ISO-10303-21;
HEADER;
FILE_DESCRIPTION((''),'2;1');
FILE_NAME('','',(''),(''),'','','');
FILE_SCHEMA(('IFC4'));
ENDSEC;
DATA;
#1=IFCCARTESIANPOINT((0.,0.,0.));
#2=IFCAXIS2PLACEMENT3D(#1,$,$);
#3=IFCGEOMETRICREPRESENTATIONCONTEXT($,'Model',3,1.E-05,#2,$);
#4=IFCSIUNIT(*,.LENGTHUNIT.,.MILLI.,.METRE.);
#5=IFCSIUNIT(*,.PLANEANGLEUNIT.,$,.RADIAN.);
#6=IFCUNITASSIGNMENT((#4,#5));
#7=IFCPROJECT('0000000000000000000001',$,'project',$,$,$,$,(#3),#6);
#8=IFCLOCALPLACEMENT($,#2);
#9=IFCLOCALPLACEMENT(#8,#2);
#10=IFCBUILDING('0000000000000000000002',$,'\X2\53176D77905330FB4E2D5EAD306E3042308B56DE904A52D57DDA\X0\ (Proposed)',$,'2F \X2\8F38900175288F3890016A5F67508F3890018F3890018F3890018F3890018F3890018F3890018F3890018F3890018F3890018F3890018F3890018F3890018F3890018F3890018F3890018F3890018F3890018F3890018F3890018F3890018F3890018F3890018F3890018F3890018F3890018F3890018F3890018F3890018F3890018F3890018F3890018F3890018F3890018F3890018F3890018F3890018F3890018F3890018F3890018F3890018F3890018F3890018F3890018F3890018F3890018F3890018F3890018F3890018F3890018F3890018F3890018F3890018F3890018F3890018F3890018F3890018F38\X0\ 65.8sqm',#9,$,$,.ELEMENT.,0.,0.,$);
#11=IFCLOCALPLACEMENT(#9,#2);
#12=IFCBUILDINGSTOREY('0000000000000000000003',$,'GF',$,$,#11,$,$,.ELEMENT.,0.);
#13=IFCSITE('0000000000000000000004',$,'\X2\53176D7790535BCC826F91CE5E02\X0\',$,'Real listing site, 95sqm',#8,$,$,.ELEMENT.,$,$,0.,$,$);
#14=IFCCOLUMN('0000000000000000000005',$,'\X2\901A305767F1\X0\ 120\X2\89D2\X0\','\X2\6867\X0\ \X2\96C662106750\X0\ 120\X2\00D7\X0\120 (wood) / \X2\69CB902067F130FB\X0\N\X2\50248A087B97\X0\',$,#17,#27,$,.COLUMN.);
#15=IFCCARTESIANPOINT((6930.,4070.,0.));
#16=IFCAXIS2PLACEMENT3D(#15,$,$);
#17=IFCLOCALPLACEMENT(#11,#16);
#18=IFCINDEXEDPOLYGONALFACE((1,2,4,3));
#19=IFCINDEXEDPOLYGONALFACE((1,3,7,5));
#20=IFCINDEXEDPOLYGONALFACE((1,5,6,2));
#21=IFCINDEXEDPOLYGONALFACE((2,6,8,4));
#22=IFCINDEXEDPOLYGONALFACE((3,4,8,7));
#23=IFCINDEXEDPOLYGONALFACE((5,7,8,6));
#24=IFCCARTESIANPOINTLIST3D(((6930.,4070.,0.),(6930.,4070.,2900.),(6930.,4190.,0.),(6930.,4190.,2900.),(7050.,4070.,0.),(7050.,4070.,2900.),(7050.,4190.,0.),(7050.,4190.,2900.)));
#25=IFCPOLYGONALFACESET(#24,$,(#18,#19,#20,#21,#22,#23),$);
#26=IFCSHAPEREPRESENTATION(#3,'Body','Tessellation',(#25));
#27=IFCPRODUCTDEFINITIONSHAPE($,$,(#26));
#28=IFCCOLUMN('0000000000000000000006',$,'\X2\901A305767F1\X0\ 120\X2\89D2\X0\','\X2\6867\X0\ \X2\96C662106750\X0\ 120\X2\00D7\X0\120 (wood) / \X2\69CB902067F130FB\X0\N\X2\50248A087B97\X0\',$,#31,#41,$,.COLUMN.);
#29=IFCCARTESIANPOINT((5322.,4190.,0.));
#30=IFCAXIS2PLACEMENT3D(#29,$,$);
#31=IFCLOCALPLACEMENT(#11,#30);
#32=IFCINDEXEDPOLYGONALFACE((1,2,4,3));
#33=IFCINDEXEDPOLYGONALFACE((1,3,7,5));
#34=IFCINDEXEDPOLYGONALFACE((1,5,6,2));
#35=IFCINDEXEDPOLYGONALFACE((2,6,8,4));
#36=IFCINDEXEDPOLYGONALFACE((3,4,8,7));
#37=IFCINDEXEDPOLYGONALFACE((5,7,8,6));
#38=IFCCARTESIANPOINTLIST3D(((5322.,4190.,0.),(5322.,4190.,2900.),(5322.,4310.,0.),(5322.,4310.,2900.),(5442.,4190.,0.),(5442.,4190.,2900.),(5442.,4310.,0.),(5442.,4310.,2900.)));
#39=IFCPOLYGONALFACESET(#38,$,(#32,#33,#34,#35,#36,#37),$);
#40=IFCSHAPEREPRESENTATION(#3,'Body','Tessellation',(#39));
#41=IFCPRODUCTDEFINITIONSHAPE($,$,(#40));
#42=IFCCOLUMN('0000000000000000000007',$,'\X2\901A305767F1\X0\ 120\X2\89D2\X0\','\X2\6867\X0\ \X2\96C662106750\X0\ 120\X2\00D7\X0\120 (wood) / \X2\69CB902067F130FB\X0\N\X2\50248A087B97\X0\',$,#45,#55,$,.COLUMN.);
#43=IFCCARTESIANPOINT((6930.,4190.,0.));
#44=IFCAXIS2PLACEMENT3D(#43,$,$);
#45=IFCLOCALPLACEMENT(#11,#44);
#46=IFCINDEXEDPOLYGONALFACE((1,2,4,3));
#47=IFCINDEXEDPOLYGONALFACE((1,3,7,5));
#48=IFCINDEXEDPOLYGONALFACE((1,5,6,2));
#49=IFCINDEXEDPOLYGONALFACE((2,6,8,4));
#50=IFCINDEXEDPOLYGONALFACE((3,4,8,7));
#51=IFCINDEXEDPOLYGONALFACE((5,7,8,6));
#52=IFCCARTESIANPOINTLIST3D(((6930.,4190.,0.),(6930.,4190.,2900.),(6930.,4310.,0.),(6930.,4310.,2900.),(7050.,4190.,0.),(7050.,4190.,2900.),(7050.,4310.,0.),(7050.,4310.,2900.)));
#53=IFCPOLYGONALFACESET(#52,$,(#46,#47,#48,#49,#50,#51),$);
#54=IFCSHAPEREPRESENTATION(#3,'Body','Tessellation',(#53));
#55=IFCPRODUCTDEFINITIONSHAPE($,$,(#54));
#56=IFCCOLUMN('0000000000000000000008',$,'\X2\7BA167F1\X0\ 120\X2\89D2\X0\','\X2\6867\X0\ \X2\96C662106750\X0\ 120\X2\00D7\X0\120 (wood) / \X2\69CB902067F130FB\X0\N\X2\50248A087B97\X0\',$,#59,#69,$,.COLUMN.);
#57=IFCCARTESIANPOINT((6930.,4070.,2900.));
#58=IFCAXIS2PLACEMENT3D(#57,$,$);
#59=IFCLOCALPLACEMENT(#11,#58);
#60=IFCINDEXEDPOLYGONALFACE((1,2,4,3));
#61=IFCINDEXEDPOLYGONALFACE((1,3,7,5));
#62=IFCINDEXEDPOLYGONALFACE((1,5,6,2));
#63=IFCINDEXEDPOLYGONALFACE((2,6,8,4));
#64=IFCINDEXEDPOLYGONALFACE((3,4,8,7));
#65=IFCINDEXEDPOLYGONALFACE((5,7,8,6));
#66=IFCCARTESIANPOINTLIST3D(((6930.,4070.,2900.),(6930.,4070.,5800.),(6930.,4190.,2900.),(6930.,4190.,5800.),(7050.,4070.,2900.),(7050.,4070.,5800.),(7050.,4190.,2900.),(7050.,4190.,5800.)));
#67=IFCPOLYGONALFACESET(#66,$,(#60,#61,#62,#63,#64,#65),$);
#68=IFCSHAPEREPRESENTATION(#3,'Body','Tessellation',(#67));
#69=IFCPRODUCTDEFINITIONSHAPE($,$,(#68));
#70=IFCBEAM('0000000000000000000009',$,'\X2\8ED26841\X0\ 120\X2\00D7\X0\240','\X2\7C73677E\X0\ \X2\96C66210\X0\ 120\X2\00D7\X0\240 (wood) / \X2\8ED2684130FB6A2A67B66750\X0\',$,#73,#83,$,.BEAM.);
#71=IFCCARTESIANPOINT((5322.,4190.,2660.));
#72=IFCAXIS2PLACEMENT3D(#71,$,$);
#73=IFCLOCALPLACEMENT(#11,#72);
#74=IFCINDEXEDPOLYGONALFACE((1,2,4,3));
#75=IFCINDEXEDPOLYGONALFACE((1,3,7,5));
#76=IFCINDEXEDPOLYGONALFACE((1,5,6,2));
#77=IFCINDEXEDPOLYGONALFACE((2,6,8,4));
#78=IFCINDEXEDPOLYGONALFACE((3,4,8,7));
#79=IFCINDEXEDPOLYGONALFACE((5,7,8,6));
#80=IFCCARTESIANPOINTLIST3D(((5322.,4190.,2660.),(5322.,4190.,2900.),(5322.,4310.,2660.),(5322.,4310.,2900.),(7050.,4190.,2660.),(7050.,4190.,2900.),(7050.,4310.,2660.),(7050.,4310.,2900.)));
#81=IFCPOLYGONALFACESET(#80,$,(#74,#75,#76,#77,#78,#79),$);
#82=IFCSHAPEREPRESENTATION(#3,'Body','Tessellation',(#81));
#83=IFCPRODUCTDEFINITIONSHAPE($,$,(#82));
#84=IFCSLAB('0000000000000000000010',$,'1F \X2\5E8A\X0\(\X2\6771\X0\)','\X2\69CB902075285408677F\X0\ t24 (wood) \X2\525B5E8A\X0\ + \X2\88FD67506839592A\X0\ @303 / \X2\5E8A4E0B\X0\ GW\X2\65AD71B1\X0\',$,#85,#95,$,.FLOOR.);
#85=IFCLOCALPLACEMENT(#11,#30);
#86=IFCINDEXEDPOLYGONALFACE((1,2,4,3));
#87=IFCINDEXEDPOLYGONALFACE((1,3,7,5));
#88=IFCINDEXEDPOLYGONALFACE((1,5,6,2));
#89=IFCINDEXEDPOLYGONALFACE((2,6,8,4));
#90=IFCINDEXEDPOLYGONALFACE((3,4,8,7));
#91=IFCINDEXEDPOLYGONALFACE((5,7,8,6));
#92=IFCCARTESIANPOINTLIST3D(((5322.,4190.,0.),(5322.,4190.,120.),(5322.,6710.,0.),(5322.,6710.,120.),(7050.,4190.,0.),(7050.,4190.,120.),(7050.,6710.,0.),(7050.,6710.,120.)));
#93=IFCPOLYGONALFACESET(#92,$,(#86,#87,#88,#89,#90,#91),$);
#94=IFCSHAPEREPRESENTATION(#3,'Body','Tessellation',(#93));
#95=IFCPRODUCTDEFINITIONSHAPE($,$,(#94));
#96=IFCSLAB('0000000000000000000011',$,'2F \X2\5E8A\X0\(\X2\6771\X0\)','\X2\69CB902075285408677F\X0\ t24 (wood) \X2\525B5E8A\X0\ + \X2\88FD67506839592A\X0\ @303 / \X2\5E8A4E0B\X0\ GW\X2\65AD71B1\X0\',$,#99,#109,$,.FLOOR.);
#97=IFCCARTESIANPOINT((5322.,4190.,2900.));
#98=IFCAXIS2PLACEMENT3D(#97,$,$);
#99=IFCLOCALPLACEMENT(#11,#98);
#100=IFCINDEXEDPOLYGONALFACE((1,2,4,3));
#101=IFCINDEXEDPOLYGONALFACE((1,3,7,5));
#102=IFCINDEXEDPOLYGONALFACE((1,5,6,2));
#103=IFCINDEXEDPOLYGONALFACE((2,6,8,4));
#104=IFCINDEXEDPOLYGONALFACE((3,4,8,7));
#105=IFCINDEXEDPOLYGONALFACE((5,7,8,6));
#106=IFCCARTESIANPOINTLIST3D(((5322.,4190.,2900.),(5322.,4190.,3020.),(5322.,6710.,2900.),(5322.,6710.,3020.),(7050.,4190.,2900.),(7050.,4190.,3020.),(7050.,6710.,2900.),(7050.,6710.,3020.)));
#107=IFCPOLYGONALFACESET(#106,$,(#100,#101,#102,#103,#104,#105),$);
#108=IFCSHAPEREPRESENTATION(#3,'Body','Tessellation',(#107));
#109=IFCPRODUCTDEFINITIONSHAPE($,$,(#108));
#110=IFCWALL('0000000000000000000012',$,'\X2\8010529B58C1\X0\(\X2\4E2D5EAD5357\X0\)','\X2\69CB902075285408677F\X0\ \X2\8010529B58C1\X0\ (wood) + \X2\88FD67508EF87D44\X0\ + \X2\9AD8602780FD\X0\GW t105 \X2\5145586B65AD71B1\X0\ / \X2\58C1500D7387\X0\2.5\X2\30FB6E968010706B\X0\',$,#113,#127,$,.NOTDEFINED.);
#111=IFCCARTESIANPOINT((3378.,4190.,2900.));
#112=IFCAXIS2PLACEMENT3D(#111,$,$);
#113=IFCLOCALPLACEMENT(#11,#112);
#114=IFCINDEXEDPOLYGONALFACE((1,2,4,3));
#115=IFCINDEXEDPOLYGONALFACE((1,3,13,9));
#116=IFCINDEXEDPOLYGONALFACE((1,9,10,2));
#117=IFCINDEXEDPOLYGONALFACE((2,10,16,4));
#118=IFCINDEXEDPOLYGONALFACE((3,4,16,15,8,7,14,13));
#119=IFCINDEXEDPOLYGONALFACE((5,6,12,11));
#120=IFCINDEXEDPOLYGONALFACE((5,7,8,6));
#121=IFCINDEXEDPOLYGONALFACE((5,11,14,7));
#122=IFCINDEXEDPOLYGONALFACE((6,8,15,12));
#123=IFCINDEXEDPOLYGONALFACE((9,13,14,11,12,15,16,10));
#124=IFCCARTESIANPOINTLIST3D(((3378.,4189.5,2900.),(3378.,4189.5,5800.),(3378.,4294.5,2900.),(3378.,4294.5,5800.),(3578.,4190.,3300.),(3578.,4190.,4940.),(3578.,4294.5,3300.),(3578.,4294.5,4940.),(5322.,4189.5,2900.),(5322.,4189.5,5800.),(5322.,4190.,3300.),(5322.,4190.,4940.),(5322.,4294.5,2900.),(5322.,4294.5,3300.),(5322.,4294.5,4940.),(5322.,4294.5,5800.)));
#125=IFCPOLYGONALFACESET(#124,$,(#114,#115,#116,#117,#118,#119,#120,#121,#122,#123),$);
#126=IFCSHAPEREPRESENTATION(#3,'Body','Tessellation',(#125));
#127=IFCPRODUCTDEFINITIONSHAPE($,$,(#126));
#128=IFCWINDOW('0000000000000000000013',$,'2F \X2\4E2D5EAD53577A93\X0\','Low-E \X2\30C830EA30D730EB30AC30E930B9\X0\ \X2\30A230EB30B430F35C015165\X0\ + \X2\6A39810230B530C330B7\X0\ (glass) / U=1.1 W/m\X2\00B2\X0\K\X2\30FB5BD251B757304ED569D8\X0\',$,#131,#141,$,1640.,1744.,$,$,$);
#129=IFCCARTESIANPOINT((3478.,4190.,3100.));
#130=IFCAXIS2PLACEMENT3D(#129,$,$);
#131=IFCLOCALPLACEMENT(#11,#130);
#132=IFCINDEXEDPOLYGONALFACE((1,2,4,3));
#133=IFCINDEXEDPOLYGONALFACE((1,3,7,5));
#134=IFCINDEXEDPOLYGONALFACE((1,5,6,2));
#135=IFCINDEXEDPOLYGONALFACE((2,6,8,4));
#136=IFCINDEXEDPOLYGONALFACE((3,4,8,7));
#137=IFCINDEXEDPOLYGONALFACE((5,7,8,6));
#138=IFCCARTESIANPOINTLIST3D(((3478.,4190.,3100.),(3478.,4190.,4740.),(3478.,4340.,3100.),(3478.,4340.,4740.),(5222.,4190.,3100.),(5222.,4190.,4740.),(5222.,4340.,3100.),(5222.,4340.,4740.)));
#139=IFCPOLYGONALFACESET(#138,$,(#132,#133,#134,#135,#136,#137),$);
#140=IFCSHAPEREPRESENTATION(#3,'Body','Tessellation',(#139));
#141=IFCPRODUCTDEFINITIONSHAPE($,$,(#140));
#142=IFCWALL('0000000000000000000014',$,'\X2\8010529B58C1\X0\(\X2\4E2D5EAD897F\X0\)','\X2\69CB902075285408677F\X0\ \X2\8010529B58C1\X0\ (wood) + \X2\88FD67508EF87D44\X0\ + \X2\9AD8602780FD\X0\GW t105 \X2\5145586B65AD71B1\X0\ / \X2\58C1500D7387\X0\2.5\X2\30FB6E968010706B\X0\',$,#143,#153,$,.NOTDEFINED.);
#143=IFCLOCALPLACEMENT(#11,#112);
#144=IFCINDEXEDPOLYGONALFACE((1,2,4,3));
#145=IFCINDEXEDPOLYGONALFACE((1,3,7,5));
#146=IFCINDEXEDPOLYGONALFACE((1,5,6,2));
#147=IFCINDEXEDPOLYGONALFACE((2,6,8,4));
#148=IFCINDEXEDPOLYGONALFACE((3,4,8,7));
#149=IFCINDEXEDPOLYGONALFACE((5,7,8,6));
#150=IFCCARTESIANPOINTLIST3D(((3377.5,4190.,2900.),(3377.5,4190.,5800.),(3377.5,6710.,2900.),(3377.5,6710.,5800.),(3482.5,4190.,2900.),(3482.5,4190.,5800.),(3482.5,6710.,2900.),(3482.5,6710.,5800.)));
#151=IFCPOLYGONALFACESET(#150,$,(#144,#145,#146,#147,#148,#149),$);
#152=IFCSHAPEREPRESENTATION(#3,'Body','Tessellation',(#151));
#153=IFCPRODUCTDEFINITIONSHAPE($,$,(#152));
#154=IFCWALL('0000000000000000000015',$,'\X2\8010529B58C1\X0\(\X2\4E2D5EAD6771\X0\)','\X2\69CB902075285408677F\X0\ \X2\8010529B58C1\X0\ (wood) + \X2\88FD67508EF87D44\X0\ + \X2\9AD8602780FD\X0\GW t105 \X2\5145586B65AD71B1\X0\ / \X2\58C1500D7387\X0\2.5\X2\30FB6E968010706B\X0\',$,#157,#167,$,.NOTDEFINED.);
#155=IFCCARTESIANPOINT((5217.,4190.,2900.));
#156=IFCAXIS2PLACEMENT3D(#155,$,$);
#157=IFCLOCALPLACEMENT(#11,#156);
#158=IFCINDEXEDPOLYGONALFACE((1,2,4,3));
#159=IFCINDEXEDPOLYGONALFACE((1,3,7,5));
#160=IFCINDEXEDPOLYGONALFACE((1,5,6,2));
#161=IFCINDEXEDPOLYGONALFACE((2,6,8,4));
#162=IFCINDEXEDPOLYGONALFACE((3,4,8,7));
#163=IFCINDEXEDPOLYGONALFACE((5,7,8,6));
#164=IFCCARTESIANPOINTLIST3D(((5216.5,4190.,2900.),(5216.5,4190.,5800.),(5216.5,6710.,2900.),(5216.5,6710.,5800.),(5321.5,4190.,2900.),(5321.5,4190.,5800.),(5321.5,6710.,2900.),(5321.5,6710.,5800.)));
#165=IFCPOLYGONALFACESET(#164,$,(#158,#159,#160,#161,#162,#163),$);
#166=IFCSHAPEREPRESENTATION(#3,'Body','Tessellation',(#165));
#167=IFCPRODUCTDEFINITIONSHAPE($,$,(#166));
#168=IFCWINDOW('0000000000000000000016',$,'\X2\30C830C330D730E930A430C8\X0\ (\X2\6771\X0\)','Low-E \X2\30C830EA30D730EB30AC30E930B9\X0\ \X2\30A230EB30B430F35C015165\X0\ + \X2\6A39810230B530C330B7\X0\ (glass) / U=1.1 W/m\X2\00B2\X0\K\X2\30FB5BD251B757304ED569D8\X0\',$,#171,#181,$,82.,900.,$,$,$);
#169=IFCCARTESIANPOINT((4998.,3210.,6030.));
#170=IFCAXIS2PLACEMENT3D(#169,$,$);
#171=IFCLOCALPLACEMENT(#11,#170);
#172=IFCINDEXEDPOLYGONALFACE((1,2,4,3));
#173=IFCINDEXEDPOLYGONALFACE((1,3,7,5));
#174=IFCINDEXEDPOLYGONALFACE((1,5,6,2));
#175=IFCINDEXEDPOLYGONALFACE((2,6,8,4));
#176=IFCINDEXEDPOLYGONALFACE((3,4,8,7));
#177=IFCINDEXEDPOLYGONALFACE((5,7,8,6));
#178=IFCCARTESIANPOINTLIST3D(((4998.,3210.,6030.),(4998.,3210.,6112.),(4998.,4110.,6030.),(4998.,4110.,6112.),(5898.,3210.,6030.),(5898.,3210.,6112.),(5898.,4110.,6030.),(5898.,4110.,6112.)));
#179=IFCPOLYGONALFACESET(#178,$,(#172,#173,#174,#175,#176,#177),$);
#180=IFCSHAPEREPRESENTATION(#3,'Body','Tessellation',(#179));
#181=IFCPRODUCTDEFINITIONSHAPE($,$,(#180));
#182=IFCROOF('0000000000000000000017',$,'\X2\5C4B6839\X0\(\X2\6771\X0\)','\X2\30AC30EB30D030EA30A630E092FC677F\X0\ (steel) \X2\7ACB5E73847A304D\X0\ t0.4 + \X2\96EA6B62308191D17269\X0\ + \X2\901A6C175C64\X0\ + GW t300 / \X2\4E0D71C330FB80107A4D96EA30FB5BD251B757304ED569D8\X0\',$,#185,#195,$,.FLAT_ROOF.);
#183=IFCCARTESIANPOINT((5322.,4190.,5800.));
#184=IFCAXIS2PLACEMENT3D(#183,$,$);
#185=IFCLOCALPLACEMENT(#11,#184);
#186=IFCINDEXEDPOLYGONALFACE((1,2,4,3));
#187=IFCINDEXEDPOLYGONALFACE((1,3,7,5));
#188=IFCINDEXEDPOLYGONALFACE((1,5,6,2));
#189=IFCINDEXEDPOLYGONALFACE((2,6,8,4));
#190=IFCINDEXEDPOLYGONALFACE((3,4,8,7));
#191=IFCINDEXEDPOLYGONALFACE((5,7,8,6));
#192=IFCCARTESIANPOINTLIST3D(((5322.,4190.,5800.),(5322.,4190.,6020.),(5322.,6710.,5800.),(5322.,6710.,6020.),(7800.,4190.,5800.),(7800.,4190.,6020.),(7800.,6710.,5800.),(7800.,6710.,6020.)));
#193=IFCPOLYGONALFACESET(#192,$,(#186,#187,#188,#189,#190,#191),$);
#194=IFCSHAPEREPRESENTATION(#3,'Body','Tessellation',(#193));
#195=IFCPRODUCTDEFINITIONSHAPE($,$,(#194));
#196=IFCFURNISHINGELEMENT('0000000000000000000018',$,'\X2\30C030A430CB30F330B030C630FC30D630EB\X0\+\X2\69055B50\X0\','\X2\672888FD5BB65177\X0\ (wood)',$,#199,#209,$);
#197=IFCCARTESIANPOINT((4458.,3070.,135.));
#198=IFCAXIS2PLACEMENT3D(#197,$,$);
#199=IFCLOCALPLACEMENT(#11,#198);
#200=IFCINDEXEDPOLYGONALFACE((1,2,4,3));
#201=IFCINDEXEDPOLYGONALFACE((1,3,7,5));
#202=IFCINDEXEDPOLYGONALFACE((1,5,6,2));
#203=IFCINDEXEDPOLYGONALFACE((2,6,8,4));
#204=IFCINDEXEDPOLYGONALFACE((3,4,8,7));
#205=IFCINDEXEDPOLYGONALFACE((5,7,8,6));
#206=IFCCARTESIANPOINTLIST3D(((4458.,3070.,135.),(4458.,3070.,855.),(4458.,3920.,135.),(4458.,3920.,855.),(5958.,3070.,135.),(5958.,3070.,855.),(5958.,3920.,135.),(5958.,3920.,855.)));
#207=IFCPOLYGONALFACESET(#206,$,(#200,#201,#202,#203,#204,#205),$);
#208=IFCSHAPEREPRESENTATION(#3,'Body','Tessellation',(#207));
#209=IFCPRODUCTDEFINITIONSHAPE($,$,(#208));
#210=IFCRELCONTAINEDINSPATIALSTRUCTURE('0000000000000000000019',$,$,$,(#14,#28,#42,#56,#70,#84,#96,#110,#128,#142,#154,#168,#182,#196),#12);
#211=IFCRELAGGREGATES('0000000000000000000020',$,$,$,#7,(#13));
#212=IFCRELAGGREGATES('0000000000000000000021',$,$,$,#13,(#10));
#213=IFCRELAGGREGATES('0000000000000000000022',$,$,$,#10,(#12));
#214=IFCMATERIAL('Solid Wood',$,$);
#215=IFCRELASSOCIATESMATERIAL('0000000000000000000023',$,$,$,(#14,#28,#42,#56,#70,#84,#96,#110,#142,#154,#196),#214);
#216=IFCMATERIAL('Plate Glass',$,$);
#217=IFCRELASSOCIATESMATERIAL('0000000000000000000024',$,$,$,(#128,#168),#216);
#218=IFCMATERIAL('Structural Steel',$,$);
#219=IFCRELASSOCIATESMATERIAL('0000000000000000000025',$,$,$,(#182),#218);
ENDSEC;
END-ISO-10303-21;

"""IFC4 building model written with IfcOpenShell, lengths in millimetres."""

from ifc_helpers import new_model, si_unit, frame, frame_2d, origin, place, context, project, spatial, rectangle, extrude, material, element, fill, save


model = new_model("IFC4")

# Units and contexts
model_context = context("Model", 3, precision=1e-05, world=origin())
ifc_project = project(units=[si_unit("LENGTHUNIT", "METRE", prefix="MILLI"), si_unit("PLANEANGLEUNIT", "RADIAN")], contexts=[model_context])

# Site, building, storey
site_placement = place(None, origin())
site = spatial("IfcSite", under=ifc_project, at=site_placement, Name="北海道富良野市", ObjectType="Real listing site, 95sqm", CompositionType="ELEMENT", RefElevation=0.0)
building_placement = place(site_placement, origin())
building = spatial("IfcBuilding", under=site, at=building_placement, Name="北海道・中庭のある回遊動線 (Proposed)", ObjectType="2F 輸送用輸送機材輸送輸送輸送輸送輸送輸送輸送輸送輸送輸送輸送輸送輸送輸送輸送輸送輸送輸送輸送輸送輸送輸送輸送輸送輸送輸送輸送輸送輸送輸送輸送輸送輸送輸送輸送輸送輸送輸送輸送輸送輸送輸送輸送輸送輸送輸送輸送輸送輸送輸送輸送輸送輸送輸送輸送輸送輸 65.8sqm", CompositionType="ELEMENT", ElevationOfRefHeight=0.0, ElevationOfTerrain=0.0)
storey_placement = place(building_placement, origin())
storey = spatial("IfcBuildingStorey", under=building, at=storey_placement, Name="GF", CompositionType="ELEMENT", Elevation=0.0)

# Columns
ifc_material_1 = material(Name="Solid Wood")
column_1_placement = place(storey_placement, frame((6930.0, 4070.0, 0.0)))
element("IfcColumn", 1, at=column_1_placement, inside=storey, material=ifc_material_1, Name="通し柱 120角", Description="桧 集成材 120×120 (wood) / 構造柱・N値計算", PredefinedType="COLUMN", context=model_context, shape_type="SweptSolid", body=[
    extrude(rectangle(XDim=120.0, YDim=120.0, at=frame_2d((60.0, 60.0))), frame((6930.0, 4070.0, 0.0)), (0.0, 0.0, 1.0), 2900.0),
])
column_2_placement = place(storey_placement, frame((5322.0, 4190.0, 0.0)))
element("IfcColumn", 2, at=column_2_placement, inside=storey, material=ifc_material_1, Name="通し柱 120角", Description="桧 集成材 120×120 (wood) / 構造柱・N値計算", PredefinedType="COLUMN", context=model_context, shape_type="SweptSolid", body=[
    extrude(rectangle(XDim=120.0, YDim=120.0, at=frame_2d((60.0, 60.0))), frame((5322.0, 4190.0, 0.0)), (0.0, 0.0, 1.0), 2900.0),
])
column_3_placement = place(storey_placement, frame((6930.0, 4190.0, 0.0)))
element("IfcColumn", 3, at=column_3_placement, inside=storey, material=ifc_material_1, Name="通し柱 120角", Description="桧 集成材 120×120 (wood) / 構造柱・N値計算", PredefinedType="COLUMN", context=model_context, shape_type="SweptSolid", body=[
    extrude(rectangle(XDim=120.0, YDim=120.0, at=frame_2d((60.0, 60.0))), frame((6930.0, 4190.0, 0.0)), (0.0, 0.0, 1.0), 2900.0),
])
column_4_placement = place(storey_placement, frame((6930.0, 4070.0, 2900.0)))
element("IfcColumn", 4, at=column_4_placement, inside=storey, material=ifc_material_1, Name="管柱 120角", Description="桧 集成材 120×120 (wood) / 構造柱・N値計算", PredefinedType="COLUMN", context=model_context, shape_type="SweptSolid", body=[
    extrude(rectangle(XDim=120.0, YDim=120.0, at=frame_2d((60.0, 60.0))), frame((6930.0, 4070.0, 2900.0)), (0.0, 0.0, 1.0), 2900.0),
])

# Beam
beam_1_placement = place(storey_placement, frame((5322.0, 4190.0, 2660.0)))
element("IfcBeam", 5, at=beam_1_placement, inside=storey, material=ifc_material_1, Name="軒桁 120×240", Description="米松 集成 120×240 (wood) / 軒桁・横架材", PredefinedType="BEAM", context=model_context, shape_type="SweptSolid", body=[
    extrude(rectangle(XDim=1728.0, YDim=120.0, at=frame_2d((864.0, 60.0))), frame((5322.0, 4190.0, 2660.0)), (0.0, 0.0, 1.0), 240.0),
])

# Slabs
slab_1_placement = place(storey_placement, frame((5322.0, 4190.0, 0.0)))
element("IfcSlab", 6, at=slab_1_placement, inside=storey, material=ifc_material_1, Name="1F 床(東)", Description="構造用合板 t24 (wood) 剛床 + 製材根太 @303 / 床下 GW断熱", PredefinedType="FLOOR", context=model_context, shape_type="SweptSolid", body=[
    extrude(rectangle(XDim=1728.0, YDim=2520.0, at=frame_2d((864.0, 1260.0))), frame((5322.0, 4190.0, 0.0)), (0.0, 0.0, 1.0), 120.0),
])
slab_2_placement = place(storey_placement, frame((5322.0, 4190.0, 2900.0)))
element("IfcSlab", 7, at=slab_2_placement, inside=storey, material=ifc_material_1, Name="2F 床(東)", Description="構造用合板 t24 (wood) 剛床 + 製材根太 @303 / 床下 GW断熱", PredefinedType="FLOOR", context=model_context, shape_type="SweptSolid", body=[
    extrude(rectangle(XDim=1728.0, YDim=2520.0, at=frame_2d((864.0, 1260.0))), frame((5322.0, 4190.0, 2900.0)), (0.0, 0.0, 1.0), 120.0),
])

# Wall, opening, window
wall_1_placement = place(storey_placement, frame((3378.0, 4190.0, 2900.0)))
wall_1 = element("IfcWall", 8, at=wall_1_placement, inside=storey, material=ifc_material_1, Name="耐力壁(中庭南)", Description="構造用合板 耐力壁 (wood) + 製材軸組 + 高性能GW t105 充填断熱 / 壁倍率2.5・準耐火", PredefinedType="NOTDEFINED", context=model_context, shape_type="SweptSolid", body=[
    extrude(rectangle(XDim=1944.0, YDim=105.0, at=frame_2d((972.0, 52.0))), frame((3378.0, 4190.0, 2900.0)), (0.0, 0.0, 1.0), 2900.0),
])
opening_placement = place(storey_placement, frame((3478.0, 4190.0, 3100.0)))
opening = element("IfcOpeningElement", 9, at=opening_placement, cuts=wall_1, PredefinedType="NOTDEFINED", context=model_context, shape_type="SweptSolid", body=[
    extrude(rectangle(XDim=1744.0, YDim=150.0, at=frame_2d((872.0, 75.0))), frame((3478.0, 4190.0, 3100.0)), (0.0, 0.0, 1.0), 1640.0),
])
ifc_material_2 = material(Name="Plate Glass")
window_1_placement = place(storey_placement, frame((3478.0, 4190.0, 3100.0)))
window_1 = element("IfcWindow", 10, at=window_1_placement, inside=storey, material=ifc_material_2, Name="2F 中庭南窓", Description="Low-E トリプルガラス アルゴン封入 + 樹脂サッシ (glass) / U=1.1 W/m²K・寒冷地仕様", OverallHeight=1640.0, OverallWidth=1744.0, context=model_context, shape_type="SweptSolid", body=[
    extrude(rectangle(XDim=1744.0, YDim=150.0, at=frame_2d((872.0, 75.0))), frame((3478.0, 4190.0, 3100.0)), (0.0, 0.0, 1.0), 1640.0),
])
fill(opening, window_1)

# Walls
wall_2_placement = place(storey_placement, frame((3378.0, 4190.0, 2900.0)))
element("IfcWall", 11, at=wall_2_placement, inside=storey, material=ifc_material_1, Name="耐力壁(中庭西)", Description="構造用合板 耐力壁 (wood) + 製材軸組 + 高性能GW t105 充填断熱 / 壁倍率2.5・準耐火", PredefinedType="NOTDEFINED", context=model_context, shape_type="SweptSolid", body=[
    extrude(rectangle(XDim=105.0, YDim=2520.0, at=frame_2d((52.0, 1260.0))), frame((3378.0, 4190.0, 2900.0)), (0.0, 0.0, 1.0), 2900.0),
])
wall_3_placement = place(storey_placement, frame((5217.0, 4190.0, 2900.0)))
element("IfcWall", 12, at=wall_3_placement, inside=storey, material=ifc_material_1, Name="耐力壁(中庭東)", Description="構造用合板 耐力壁 (wood) + 製材軸組 + 高性能GW t105 充填断熱 / 壁倍率2.5・準耐火", PredefinedType="NOTDEFINED", context=model_context, shape_type="SweptSolid", body=[
    extrude(rectangle(XDim=105.0, YDim=2520.0, at=frame_2d((52.0, 1260.0))), frame((5217.0, 4190.0, 2900.0)), (0.0, 0.0, 1.0), 2900.0),
])

# Window
window_2_placement = place(storey_placement, frame((4998.0, 3210.0, 6030.0)))
element("IfcWindow", 13, at=window_2_placement, inside=storey, material=ifc_material_2, Name="トップライト (東)", Description="Low-E トリプルガラス アルゴン封入 + 樹脂サッシ (glass) / U=1.1 W/m²K・寒冷地仕様", OverallHeight=82.0, OverallWidth=900.0, context=model_context, shape_type="SweptSolid", body=[
    extrude(rectangle(XDim=900.0, YDim=900.0, at=frame_2d((450.0, 450.0))), frame((4998.0, 3210.0, 6030.0)), (0.0, 0.0, 1.0), 82.0),
])

# Roof
ifc_material_3 = material(Name="Structural Steel")
for number, where, name in (
    (14, (5322.0, 4190.0, 5800.0), "屋根(東)"),
):
    element("IfcRoof", number, at=place(storey_placement, frame(where)), inside=storey, material=ifc_material_3, Name=name, Description="ガルバリウム鋼板 (steel) 立平葺き t0.4 + 雪止め金物 + 通気層 + GW t300 / 不燃・耐積雪・寒冷地仕様", PredefinedType="FLAT_ROOF", context=model_context, shape_type="SweptSolid", body=[
        extrude(rectangle(XDim=2478.0, YDim=2520.0, at=frame_2d((1239.0, 1260.0))), frame((5322.0, 4190.0, 5800.0)), (0.0, 0.0, 1.0), 220.0),
    ])

# Furnishing element
furnishing_1_placement = place(storey_placement, frame((4458.0, 3070.0, 135.0)))
element("IfcFurnishingElement", 15, at=furnishing_1_placement, inside=storey, material=ifc_material_1, Name="ダイニングテーブル+椅子", Description="木製家具 (wood)", context=model_context, shape_type="SweptSolid", body=[
    extrude(rectangle(XDim=1500.0, YDim=850.0, at=frame_2d((750.0, 425.0))), frame((4458.0, 3070.0, 135.0)), (0.0, 0.0, 1.0), 720.0),
])

save(model, "model.ifc")
